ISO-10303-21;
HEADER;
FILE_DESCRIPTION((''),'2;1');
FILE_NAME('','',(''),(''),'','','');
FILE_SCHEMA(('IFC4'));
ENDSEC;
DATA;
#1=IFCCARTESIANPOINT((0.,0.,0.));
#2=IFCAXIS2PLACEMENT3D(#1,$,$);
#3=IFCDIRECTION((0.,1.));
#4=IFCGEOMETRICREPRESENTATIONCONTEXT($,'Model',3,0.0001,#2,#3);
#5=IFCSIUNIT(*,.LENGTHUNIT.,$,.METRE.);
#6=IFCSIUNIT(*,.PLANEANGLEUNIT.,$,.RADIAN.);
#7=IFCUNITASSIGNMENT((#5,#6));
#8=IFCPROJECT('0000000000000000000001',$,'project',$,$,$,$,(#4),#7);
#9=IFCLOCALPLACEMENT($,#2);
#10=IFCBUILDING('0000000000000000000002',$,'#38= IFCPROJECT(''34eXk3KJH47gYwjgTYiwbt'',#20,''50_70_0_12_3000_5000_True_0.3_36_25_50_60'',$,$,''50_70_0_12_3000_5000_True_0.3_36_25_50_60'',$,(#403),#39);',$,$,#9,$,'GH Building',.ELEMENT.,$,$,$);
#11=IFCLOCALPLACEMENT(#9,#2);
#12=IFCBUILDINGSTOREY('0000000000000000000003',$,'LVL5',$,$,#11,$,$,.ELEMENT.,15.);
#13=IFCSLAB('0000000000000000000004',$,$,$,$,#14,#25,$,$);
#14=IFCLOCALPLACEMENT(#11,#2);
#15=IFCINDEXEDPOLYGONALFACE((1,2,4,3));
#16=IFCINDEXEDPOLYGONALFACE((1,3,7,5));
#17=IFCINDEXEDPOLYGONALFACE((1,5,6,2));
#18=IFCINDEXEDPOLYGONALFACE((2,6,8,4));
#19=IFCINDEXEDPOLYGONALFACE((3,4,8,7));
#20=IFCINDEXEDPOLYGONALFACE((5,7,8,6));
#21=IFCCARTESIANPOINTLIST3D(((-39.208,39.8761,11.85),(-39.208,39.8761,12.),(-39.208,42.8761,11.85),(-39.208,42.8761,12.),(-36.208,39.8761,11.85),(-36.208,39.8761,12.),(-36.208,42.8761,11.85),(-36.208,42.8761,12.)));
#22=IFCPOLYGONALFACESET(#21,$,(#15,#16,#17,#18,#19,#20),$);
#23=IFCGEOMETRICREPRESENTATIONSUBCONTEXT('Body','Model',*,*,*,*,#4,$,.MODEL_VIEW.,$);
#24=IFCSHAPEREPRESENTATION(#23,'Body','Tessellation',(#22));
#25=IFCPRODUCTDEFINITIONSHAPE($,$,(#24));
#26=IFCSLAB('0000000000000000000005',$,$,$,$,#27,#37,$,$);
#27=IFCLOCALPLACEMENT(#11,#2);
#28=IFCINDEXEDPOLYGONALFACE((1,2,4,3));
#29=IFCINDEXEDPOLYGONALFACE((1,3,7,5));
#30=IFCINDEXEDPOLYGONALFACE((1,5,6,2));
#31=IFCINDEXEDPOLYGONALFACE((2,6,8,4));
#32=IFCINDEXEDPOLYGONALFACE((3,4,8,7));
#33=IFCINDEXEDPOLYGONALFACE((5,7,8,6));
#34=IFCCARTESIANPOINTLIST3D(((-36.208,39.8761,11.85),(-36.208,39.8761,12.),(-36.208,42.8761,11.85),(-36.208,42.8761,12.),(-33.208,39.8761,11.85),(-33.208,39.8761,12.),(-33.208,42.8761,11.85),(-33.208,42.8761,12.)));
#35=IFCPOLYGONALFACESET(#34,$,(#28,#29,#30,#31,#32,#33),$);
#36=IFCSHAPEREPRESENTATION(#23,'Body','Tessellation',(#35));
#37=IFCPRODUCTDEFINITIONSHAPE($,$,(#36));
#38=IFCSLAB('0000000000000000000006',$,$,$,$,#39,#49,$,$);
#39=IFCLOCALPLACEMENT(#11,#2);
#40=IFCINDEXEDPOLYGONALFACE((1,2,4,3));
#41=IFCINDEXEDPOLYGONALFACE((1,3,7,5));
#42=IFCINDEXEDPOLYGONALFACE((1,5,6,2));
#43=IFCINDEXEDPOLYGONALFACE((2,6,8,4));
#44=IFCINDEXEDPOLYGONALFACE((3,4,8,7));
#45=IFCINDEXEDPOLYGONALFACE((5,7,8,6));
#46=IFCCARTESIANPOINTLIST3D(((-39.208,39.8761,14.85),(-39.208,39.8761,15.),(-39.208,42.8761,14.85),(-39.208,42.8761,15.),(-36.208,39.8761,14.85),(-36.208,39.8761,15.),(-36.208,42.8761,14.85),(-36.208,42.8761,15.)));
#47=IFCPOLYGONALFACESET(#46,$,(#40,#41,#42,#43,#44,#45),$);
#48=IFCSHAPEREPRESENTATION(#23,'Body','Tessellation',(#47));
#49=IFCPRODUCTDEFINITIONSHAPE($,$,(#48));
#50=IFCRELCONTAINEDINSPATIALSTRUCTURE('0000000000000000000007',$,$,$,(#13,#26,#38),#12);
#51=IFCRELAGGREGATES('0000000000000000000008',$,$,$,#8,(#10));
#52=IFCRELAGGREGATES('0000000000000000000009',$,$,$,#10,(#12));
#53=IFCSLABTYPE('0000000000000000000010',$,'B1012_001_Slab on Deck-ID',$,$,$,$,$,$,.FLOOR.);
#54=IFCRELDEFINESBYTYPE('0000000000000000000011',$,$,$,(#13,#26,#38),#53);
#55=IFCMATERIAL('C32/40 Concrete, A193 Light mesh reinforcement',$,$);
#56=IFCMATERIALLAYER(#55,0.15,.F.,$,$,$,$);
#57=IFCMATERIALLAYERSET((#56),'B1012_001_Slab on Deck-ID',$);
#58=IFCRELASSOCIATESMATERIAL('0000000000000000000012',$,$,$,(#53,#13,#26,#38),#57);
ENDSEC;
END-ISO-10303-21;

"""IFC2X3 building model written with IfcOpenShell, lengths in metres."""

from ifc_helpers import new_model, si_unit, direction, frame, origin, place, context, subcontext, project, spatial, polyline, outline, extrude, material, layer, layer_set, layer_usage, type_object, element, save


model = new_model("IFC2X3")

# Units and contexts
model_context = context("Model", 3, precision=0.0001, world=origin(), true_north=direction((0.0, 1.0)))
body_context = subcontext(model_context, "Body", "Model", "MODEL_VIEW")
ifc_project = project(units=[si_unit("LENGTHUNIT", "METRE"), si_unit("PLANEANGLEUNIT", "RADIAN")], contexts=[model_context])

# Building, storey
building_placement = place(None, origin())
building = spatial("IfcBuilding", under=ifc_project, at=building_placement, Name="#38= IFCPROJECT('34eXk3KJH47gYwjgTYiwbt',#20,'50_70_0_12_3000_5000_True_0.3_36_25_50_60',$,$,'50_70_0_12_3000_5000_True_0.3_36_25_50_60',$,(#403),#39);", LongName="GH Building", CompositionType="ELEMENT")
storey_placement = place(building_placement, origin())
storey = spatial("IfcBuildingStorey", under=building, at=storey_placement, Name="LVL5", CompositionType="ELEMENT", Elevation=15.0)

# Slabs
ifc_material_1 = material(Name="C32/40 Concrete, A193 Light mesh reinforcement")
ifc_layer_1 = layer(ifc_material_1, 0.15, ventilated=False)
ifc_layer_set_1 = layer_set([ifc_layer_1], Name="B1012_001_Slab on Deck-ID")
slab_type_1 = type_object("IfcSlabType", Name="B1012_001_Slab on Deck-ID", PredefinedType="FLOOR", material=ifc_layer_set_1)
ifc_layer_usage_1 = layer_usage(ifc_layer_set_1, "AXIS3", "NEGATIVE", -0.15)
slab_1_placement = place(storey_placement, frame((-37.708, 41.3761, 11.85)))
element("IfcSlab", 1, at=slab_1_placement, inside=storey, type_object=slab_type_1, material=ifc_layer_usage_1, context=body_context, shape_type="SweptSolid", body=[
    extrude(outline(polyline([(1.5, -1.5), (-1.5, -1.5), (-1.5, 1.5), (1.5, 1.5), (1.5, -1.5)])), origin(), (0.0, 0.0, 1.0), 0.15),
])
ifc_layer_usage_2 = layer_usage(ifc_layer_set_1, "AXIS3", "NEGATIVE", -0.15)
slab_2_placement = place(storey_placement, frame((-34.708, 41.3761, 11.85)))
element("IfcSlab", 2, at=slab_2_placement, inside=storey, type_object=slab_type_1, material=ifc_layer_usage_2, context=body_context, shape_type="SweptSolid", body=[
    extrude(outline(polyline([(1.5, -1.5), (-1.5, -1.5), (-1.5, 1.5), (1.5, 1.5), (1.5, -1.5)])), origin(), (0.0, 0.0, 1.0), 0.15),
])
ifc_layer_usage_3 = layer_usage(ifc_layer_set_1, "AXIS3", "NEGATIVE", -0.15)
slab_3_placement = place(storey_placement, frame((-37.708, 41.3761, 14.85)))
element("IfcSlab", 3, at=slab_3_placement, inside=storey, type_object=slab_type_1, material=ifc_layer_usage_3, context=body_context, shape_type="SweptSolid", body=[
    extrude(outline(polyline([(-1.5, 1.5), (1.5, 1.5), (1.5, -1.5), (-1.5, -1.5), (-1.5, 1.5)])), origin(), (0.0, 0.0, 1.0), 0.15),
])

save(model, "model.ifc")
